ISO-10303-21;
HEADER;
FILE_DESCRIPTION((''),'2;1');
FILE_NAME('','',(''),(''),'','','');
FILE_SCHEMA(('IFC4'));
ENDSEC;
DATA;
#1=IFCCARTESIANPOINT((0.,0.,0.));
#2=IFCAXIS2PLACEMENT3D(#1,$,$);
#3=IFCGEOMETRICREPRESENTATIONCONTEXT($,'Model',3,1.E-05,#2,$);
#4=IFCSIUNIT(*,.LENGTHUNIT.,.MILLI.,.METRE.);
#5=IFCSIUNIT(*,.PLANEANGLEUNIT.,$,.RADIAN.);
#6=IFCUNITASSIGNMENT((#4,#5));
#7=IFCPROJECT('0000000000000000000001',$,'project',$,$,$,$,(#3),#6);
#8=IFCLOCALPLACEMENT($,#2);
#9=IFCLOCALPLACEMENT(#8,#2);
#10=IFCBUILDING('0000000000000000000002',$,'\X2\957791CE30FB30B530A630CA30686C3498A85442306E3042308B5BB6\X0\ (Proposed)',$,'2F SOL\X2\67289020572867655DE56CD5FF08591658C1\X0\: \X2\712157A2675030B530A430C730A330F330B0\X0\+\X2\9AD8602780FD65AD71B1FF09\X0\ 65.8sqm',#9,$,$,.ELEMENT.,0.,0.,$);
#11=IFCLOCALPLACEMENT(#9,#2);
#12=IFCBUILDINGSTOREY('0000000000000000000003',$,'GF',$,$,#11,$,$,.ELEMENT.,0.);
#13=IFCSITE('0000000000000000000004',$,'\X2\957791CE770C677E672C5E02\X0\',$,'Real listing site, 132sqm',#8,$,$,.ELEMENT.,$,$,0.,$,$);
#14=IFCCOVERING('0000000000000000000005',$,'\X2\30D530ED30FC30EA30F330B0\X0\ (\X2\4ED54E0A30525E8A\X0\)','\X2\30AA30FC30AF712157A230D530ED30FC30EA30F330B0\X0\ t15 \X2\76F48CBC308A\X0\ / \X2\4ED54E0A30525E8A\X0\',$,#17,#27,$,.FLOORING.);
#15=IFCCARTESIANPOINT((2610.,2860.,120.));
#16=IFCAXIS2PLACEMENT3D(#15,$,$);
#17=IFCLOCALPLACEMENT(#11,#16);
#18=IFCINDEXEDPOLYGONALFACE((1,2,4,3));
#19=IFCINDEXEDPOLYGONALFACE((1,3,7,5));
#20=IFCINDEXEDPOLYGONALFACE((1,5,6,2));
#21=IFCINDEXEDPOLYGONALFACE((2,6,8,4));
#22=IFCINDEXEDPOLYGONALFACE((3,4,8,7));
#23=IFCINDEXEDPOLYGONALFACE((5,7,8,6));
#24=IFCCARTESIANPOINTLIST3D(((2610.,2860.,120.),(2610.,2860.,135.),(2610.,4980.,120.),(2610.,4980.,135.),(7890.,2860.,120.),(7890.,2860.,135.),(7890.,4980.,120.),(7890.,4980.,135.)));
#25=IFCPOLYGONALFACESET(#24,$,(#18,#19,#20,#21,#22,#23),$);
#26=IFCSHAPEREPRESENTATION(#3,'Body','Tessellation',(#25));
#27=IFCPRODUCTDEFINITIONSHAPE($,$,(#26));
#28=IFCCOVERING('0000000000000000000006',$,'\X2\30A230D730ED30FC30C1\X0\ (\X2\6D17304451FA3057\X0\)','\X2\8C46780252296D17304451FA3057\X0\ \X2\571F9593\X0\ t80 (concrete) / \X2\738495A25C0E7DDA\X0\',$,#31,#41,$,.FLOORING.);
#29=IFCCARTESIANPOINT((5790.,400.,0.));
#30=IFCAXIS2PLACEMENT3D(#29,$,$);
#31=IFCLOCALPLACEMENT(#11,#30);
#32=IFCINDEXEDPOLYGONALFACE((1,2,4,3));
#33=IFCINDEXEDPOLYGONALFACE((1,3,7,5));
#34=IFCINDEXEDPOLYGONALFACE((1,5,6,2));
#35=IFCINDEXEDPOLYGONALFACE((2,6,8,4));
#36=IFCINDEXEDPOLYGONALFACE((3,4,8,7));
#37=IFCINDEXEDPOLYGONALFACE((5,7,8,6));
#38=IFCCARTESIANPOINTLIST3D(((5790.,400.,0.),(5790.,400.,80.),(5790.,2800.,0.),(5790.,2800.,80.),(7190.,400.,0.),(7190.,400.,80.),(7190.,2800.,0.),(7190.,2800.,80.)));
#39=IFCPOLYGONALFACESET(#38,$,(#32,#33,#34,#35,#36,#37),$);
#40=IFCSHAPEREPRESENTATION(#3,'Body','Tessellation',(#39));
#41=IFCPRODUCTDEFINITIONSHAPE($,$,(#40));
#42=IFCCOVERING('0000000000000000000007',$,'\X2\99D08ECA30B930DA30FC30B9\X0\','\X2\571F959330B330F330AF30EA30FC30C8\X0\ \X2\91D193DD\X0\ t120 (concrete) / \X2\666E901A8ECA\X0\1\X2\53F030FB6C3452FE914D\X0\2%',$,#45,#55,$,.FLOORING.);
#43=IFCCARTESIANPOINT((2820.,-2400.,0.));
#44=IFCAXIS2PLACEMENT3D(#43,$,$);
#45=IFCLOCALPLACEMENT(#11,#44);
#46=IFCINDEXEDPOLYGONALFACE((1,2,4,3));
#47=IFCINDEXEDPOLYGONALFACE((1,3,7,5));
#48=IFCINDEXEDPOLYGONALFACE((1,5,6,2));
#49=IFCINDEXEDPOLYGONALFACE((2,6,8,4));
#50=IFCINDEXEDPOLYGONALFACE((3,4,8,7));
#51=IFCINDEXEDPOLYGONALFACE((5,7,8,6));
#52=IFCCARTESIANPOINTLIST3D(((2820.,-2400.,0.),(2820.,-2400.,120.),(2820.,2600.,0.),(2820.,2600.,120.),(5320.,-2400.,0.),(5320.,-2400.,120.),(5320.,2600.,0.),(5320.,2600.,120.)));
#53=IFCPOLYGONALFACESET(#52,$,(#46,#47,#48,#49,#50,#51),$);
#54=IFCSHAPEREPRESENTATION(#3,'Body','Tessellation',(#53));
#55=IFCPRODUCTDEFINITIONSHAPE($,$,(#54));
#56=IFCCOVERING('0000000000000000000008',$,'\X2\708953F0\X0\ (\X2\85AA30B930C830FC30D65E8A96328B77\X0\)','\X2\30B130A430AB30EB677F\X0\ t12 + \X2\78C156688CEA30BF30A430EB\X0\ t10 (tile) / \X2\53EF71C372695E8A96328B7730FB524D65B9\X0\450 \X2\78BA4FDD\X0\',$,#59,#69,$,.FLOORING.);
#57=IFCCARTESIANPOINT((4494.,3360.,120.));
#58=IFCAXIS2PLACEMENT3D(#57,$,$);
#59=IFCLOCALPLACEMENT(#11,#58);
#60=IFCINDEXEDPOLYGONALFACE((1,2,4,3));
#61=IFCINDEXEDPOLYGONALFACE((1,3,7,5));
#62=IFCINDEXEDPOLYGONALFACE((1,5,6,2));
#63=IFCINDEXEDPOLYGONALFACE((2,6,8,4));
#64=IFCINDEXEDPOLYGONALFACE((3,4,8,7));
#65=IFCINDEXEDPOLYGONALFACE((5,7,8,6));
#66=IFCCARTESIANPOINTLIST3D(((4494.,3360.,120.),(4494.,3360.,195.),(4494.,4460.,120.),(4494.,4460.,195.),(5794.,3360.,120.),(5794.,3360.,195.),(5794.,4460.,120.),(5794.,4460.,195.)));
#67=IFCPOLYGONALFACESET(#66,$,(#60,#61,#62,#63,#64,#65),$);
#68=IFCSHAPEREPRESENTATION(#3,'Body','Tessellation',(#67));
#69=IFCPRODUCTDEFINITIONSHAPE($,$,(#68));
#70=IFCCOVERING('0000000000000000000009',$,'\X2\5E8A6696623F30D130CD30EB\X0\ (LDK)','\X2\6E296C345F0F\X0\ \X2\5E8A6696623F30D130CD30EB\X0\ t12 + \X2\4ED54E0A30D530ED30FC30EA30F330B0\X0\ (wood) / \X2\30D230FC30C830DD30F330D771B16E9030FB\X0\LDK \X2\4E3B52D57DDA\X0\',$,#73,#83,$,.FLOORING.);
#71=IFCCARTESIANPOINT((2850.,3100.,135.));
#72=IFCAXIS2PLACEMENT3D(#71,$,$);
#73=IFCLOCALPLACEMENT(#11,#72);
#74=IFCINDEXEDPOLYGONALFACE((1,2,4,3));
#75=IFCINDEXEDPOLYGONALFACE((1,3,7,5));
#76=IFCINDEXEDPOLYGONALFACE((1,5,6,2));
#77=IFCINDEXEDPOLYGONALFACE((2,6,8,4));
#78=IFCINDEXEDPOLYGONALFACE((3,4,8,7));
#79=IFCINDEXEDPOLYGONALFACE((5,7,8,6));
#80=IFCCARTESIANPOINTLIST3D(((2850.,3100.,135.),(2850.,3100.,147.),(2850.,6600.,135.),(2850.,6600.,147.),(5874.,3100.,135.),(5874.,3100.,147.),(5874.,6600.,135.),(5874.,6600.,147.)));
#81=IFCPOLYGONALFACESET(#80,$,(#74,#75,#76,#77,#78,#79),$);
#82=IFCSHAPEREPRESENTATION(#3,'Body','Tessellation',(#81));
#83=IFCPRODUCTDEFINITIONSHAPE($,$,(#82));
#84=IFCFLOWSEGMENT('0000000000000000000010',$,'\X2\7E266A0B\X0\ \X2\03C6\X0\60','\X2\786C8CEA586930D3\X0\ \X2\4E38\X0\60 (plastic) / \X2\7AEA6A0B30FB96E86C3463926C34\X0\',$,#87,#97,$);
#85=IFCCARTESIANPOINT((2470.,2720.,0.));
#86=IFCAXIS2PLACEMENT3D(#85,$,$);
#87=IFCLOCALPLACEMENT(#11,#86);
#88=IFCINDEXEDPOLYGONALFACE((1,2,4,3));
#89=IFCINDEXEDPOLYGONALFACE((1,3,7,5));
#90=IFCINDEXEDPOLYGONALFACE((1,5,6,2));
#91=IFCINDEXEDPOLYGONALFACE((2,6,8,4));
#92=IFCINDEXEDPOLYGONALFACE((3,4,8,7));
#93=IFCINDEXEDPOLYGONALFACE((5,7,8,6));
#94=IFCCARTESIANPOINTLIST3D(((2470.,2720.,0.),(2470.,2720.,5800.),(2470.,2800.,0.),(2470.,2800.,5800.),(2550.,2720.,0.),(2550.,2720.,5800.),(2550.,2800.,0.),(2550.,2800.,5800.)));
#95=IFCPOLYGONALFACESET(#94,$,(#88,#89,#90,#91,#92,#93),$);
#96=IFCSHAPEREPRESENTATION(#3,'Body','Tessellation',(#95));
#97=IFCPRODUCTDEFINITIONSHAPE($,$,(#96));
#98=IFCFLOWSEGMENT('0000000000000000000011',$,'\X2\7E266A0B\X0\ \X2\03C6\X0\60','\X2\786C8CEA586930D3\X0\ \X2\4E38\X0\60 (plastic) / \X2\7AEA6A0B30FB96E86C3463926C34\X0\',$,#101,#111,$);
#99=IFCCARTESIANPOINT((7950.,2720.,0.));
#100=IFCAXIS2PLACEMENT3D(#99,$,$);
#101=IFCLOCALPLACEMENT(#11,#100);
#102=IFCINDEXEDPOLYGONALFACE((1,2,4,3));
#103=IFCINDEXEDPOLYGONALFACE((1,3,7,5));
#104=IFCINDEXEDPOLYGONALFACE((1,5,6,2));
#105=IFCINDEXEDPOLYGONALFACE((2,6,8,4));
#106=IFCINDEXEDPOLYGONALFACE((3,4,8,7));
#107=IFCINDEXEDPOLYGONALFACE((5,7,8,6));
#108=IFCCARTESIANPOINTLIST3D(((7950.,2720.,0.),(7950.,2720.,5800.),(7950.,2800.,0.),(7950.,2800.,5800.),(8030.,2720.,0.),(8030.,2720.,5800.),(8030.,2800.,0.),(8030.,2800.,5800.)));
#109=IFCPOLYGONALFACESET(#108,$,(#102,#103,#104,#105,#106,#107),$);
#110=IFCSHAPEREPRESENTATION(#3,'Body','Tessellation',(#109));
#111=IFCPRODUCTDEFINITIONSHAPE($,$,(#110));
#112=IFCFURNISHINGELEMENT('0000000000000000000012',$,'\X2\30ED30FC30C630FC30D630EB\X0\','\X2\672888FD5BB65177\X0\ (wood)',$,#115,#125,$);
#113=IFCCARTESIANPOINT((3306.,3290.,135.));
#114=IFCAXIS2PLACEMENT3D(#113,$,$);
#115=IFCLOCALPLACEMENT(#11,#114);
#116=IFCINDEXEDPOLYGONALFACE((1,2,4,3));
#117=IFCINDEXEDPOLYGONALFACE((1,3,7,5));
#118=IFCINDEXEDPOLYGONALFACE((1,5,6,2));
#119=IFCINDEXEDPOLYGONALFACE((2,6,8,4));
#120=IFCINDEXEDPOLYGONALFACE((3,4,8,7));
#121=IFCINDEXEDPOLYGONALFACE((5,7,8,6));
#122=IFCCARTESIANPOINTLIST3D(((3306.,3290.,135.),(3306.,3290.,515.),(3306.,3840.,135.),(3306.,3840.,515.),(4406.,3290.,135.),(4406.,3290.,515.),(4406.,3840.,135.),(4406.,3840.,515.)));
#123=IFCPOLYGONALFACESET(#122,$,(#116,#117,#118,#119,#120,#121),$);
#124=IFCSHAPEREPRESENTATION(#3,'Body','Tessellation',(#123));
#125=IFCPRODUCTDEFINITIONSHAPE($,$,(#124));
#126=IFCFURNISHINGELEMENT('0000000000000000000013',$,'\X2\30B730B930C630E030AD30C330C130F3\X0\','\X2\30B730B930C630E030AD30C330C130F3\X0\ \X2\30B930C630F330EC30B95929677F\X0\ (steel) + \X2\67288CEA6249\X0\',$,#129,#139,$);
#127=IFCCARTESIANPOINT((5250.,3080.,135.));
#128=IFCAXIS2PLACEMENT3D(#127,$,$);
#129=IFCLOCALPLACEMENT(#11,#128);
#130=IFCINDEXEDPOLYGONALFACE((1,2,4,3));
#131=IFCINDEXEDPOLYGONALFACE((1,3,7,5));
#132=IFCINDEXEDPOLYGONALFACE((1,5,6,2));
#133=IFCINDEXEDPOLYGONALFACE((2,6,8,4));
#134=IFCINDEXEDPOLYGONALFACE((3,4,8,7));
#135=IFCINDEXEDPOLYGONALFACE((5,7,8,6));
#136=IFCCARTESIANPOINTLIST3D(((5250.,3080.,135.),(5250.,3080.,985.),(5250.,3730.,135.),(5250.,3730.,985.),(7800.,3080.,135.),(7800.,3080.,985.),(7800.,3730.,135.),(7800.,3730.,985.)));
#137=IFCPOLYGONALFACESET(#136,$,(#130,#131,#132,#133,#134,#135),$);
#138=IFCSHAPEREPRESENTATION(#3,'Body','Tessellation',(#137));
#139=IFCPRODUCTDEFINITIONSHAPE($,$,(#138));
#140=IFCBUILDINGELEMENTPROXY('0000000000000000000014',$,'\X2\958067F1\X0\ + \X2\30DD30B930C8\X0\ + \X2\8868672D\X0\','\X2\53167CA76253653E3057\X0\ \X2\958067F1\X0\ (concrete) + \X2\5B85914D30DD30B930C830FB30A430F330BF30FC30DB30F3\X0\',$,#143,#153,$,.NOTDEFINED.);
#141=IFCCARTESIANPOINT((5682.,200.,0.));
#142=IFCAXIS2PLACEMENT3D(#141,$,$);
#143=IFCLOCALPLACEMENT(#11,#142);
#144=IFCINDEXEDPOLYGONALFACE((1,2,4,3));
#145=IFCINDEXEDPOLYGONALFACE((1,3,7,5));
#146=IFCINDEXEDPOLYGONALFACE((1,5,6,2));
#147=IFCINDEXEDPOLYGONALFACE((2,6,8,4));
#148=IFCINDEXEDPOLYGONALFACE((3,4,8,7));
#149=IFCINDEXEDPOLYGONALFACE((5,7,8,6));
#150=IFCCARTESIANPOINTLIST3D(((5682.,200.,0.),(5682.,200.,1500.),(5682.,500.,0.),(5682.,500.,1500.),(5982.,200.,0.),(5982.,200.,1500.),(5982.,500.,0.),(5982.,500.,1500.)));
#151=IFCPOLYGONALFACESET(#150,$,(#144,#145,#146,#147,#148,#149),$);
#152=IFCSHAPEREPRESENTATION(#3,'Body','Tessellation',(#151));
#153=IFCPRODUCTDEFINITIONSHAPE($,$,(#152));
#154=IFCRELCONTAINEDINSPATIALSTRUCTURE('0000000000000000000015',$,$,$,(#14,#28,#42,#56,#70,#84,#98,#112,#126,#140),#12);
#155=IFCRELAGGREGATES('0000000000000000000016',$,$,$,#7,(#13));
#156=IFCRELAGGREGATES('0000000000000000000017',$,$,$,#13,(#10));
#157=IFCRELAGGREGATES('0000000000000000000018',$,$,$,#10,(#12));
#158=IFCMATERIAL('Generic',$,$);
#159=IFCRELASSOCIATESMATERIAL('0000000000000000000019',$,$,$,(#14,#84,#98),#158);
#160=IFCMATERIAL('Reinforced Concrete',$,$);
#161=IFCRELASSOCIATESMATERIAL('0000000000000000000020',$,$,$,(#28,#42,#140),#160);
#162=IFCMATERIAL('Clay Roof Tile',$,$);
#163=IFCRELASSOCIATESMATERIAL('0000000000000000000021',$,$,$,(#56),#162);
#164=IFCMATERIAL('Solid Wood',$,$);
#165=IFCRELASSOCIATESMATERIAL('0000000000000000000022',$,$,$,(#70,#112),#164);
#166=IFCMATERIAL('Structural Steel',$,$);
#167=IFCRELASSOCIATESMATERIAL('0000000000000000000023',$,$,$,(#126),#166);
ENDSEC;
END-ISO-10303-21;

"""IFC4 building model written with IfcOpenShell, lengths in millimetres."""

from ifc_helpers import new_model, si_unit, frame, frame_2d, origin, place, context, project, spatial, rectangle, extrude, material, element, save


model = new_model("IFC4")

# Units and contexts
model_context = context("Model", 3, precision=1e-05, world=origin())
ifc_project = project(units=[si_unit("LENGTHUNIT", "METRE", prefix="MILLI"), si_unit("PLANEANGLEUNIT", "RADIAN")], contexts=[model_context])

# Site, building, storey
site_placement = place(None, origin())
site = spatial("IfcSite", under=ifc_project, at=site_placement, Name="長野県松本市", ObjectType="Real listing site, 132sqm", CompositionType="ELEMENT", RefElevation=0.0)
building_placement = place(site_placement, origin())
building = spatial("IfcBuilding", under=site, at=building_placement, Name="長野・サウナと水風呂のある家 (Proposed)", ObjectType="2F SOL木造在来工法（外壁: 無垢材サイディング+高性能断熱） 65.8sqm", CompositionType="ELEMENT", ElevationOfRefHeight=0.0, ElevationOfTerrain=0.0)
storey_placement = place(building_placement, origin())
storey = spatial("IfcBuildingStorey", under=building, at=storey_placement, Name="GF", CompositionType="ELEMENT", Elevation=0.0)

# Shared definitions
ifc_material_1 = material(Name="Solid Wood")

# Shared definitions
ifc_material_2 = material(Name="Reinforced Concrete")

# Coverings
ifc_material_3 = material(Name="Generic")
covering_1_placement = place(storey_placement, frame((2610.0, 2860.0, 120.0)))
element("IfcCovering", 1, at=covering_1_placement, inside=storey, material=ifc_material_3, Name="フローリング (仕上げ床)", Description="オーク無垢フローリング t15 直貼り / 仕上げ床", PredefinedType="FLOORING", context=model_context, shape_type="SweptSolid", body=[
    extrude(rectangle(XDim=5280.0, YDim=2120.0, at=frame_2d((2640.0, 1060.0))), frame((2610.0, 2860.0, 120.0)), (0.0, 0.0, 1.0), 15.0),
])
covering_2_placement = place(storey_placement, frame((5790.0, 400.0, 0.0)))
element("IfcCovering", 2, at=covering_2_placement, inside=storey, material=ifc_material_2, Name="アプローチ (洗い出し)", Description="豆砂利洗い出し 土間 t80 (concrete) / 玄関導線", PredefinedType="FLOORING", context=model_context, shape_type="SweptSolid", body=[
    extrude(rectangle(XDim=1400.0, YDim=2400.0, at=frame_2d((700.0, 1200.0))), frame((5790.0, 400.0, 0.0)), (0.0, 0.0, 1.0), 80.0),
])
covering_3_placement = place(storey_placement, frame((2820.0, -2400.0, 0.0)))
element("IfcCovering", 3, at=covering_3_placement, inside=storey, material=ifc_material_2, Name="駐車スペース", Description="土間コンクリート 金鏝 t120 (concrete) / 普通車1台・水勾配2%", PredefinedType="FLOORING", context=model_context, shape_type="SweptSolid", body=[
    extrude(rectangle(XDim=2500.0, YDim=5000.0, at=frame_2d((1250.0, 2500.0))), frame((2820.0, -2400.0, 0.0)), (0.0, 0.0, 1.0), 120.0),
])
ifc_material_4 = material(Name="Clay Roof Tile")
covering_4_placement = place(storey_placement, frame((4494.0, 3360.0, 120.0)))
element("IfcCovering", 4, at=covering_4_placement, inside=storey, material=ifc_material_4, Name="炉台 (薪ストーブ床防護)", Description="ケイカル板 t12 + 磁器質タイル t10 (tile) / 可燃物床防護・前方450 確保", PredefinedType="FLOORING", context=model_context, shape_type="SweptSolid", body=[
    extrude(rectangle(XDim=1300.0, YDim=1100.0, at=frame_2d((650.0, 550.0))), frame((4494.0, 3360.0, 120.0)), (0.0, 0.0, 1.0), 75.0),
])
covering_5_placement = place(storey_placement, frame((2850.0, 3100.0, 135.0)))
element("IfcCovering", 5, at=covering_5_placement, inside=storey, material=ifc_material_1, Name="床暖房パネル (LDK)", Description="温水式 床暖房パネル t12 + 仕上フローリング (wood) / ヒートポンプ熱源・LDK 主動線", PredefinedType="FLOORING", context=model_context, shape_type="SweptSolid", body=[
    extrude(rectangle(XDim=3024.0, YDim=3500.0, at=frame_2d((1512.0, 1750.0))), frame((2850.0, 3100.0, 135.0)), (0.0, 0.0, 1.0), 12.0),
])

# Flow segments
flow_segment_1_placement = place(storey_placement, frame((2470.0, 2720.0, 0.0)))
element("IfcFlowSegment", 6, at=flow_segment_1_placement, inside=storey, material=ifc_material_3, Name="縦樋 φ60", Description="硬質塩ビ 丸60 (plastic) / 竪樋・雨水排水", context=model_context, shape_type="SweptSolid", body=[
    extrude(rectangle(XDim=80.0, YDim=80.0, at=frame_2d((40.0, 40.0))), frame((2470.0, 2720.0, 0.0)), (0.0, 0.0, 1.0), 5800.0),
])
flow_segment_2_placement = place(storey_placement, frame((7950.0, 2720.0, 0.0)))
element("IfcFlowSegment", 7, at=flow_segment_2_placement, inside=storey, material=ifc_material_3, Name="縦樋 φ60", Description="硬質塩ビ 丸60 (plastic) / 竪樋・雨水排水", context=model_context, shape_type="SweptSolid", body=[
    extrude(rectangle(XDim=80.0, YDim=80.0, at=frame_2d((40.0, 40.0))), frame((7950.0, 2720.0, 0.0)), (0.0, 0.0, 1.0), 5800.0),
])

# Furnishing elements
furnishing_1_placement = place(storey_placement, frame((3306.0, 3290.0, 135.0)))
element("IfcFurnishingElement", 8, at=furnishing_1_placement, inside=storey, material=ifc_material_1, Name="ローテーブル", Description="木製家具 (wood)", context=model_context, shape_type="SweptSolid", body=[
    extrude(rectangle(XDim=1100.0, YDim=550.0, at=frame_2d((550.0, 275.0))), frame((3306.0, 3290.0, 135.0)), (0.0, 0.0, 1.0), 380.0),
])
ifc_material_5 = material(Name="Structural Steel")
furnishing_2_placement = place(storey_placement, frame((5250.0, 3080.0, 135.0)))
element("IfcFurnishingElement", 9, at=furnishing_2_placement, inside=storey, material=ifc_material_5, Name="システムキッチン", Description="システムキッチン ステンレス天板 (steel) + 木質扉", context=model_context, shape_type="SweptSolid", body=[
    extrude(rectangle(XDim=2550.0, YDim=650.0, at=frame_2d((1275.0, 325.0))), frame((5250.0, 3080.0, 135.0)), (0.0, 0.0, 1.0), 850.0),
])

# Building element proxy
proxy_placement = place(storey_placement, frame((5682.0, 200.0, 0.0)))
element("IfcBuildingElementProxy", 10, at=proxy_placement, inside=storey, material=ifc_material_2, Name="門柱 + ポスト + 表札", Description="化粧打放し 門柱 (concrete) + 宅配ポスト・インターホン", PredefinedType="NOTDEFINED", context=model_context, shape_type="SweptSolid", body=[
    extrude(rectangle(XDim=300.0, YDim=300.0, at=frame_2d((150.0, 150.0))), frame((5682.0, 200.0, 0.0)), (0.0, 0.0, 1.0), 1500.0),
])

save(model, "model.ifc")
